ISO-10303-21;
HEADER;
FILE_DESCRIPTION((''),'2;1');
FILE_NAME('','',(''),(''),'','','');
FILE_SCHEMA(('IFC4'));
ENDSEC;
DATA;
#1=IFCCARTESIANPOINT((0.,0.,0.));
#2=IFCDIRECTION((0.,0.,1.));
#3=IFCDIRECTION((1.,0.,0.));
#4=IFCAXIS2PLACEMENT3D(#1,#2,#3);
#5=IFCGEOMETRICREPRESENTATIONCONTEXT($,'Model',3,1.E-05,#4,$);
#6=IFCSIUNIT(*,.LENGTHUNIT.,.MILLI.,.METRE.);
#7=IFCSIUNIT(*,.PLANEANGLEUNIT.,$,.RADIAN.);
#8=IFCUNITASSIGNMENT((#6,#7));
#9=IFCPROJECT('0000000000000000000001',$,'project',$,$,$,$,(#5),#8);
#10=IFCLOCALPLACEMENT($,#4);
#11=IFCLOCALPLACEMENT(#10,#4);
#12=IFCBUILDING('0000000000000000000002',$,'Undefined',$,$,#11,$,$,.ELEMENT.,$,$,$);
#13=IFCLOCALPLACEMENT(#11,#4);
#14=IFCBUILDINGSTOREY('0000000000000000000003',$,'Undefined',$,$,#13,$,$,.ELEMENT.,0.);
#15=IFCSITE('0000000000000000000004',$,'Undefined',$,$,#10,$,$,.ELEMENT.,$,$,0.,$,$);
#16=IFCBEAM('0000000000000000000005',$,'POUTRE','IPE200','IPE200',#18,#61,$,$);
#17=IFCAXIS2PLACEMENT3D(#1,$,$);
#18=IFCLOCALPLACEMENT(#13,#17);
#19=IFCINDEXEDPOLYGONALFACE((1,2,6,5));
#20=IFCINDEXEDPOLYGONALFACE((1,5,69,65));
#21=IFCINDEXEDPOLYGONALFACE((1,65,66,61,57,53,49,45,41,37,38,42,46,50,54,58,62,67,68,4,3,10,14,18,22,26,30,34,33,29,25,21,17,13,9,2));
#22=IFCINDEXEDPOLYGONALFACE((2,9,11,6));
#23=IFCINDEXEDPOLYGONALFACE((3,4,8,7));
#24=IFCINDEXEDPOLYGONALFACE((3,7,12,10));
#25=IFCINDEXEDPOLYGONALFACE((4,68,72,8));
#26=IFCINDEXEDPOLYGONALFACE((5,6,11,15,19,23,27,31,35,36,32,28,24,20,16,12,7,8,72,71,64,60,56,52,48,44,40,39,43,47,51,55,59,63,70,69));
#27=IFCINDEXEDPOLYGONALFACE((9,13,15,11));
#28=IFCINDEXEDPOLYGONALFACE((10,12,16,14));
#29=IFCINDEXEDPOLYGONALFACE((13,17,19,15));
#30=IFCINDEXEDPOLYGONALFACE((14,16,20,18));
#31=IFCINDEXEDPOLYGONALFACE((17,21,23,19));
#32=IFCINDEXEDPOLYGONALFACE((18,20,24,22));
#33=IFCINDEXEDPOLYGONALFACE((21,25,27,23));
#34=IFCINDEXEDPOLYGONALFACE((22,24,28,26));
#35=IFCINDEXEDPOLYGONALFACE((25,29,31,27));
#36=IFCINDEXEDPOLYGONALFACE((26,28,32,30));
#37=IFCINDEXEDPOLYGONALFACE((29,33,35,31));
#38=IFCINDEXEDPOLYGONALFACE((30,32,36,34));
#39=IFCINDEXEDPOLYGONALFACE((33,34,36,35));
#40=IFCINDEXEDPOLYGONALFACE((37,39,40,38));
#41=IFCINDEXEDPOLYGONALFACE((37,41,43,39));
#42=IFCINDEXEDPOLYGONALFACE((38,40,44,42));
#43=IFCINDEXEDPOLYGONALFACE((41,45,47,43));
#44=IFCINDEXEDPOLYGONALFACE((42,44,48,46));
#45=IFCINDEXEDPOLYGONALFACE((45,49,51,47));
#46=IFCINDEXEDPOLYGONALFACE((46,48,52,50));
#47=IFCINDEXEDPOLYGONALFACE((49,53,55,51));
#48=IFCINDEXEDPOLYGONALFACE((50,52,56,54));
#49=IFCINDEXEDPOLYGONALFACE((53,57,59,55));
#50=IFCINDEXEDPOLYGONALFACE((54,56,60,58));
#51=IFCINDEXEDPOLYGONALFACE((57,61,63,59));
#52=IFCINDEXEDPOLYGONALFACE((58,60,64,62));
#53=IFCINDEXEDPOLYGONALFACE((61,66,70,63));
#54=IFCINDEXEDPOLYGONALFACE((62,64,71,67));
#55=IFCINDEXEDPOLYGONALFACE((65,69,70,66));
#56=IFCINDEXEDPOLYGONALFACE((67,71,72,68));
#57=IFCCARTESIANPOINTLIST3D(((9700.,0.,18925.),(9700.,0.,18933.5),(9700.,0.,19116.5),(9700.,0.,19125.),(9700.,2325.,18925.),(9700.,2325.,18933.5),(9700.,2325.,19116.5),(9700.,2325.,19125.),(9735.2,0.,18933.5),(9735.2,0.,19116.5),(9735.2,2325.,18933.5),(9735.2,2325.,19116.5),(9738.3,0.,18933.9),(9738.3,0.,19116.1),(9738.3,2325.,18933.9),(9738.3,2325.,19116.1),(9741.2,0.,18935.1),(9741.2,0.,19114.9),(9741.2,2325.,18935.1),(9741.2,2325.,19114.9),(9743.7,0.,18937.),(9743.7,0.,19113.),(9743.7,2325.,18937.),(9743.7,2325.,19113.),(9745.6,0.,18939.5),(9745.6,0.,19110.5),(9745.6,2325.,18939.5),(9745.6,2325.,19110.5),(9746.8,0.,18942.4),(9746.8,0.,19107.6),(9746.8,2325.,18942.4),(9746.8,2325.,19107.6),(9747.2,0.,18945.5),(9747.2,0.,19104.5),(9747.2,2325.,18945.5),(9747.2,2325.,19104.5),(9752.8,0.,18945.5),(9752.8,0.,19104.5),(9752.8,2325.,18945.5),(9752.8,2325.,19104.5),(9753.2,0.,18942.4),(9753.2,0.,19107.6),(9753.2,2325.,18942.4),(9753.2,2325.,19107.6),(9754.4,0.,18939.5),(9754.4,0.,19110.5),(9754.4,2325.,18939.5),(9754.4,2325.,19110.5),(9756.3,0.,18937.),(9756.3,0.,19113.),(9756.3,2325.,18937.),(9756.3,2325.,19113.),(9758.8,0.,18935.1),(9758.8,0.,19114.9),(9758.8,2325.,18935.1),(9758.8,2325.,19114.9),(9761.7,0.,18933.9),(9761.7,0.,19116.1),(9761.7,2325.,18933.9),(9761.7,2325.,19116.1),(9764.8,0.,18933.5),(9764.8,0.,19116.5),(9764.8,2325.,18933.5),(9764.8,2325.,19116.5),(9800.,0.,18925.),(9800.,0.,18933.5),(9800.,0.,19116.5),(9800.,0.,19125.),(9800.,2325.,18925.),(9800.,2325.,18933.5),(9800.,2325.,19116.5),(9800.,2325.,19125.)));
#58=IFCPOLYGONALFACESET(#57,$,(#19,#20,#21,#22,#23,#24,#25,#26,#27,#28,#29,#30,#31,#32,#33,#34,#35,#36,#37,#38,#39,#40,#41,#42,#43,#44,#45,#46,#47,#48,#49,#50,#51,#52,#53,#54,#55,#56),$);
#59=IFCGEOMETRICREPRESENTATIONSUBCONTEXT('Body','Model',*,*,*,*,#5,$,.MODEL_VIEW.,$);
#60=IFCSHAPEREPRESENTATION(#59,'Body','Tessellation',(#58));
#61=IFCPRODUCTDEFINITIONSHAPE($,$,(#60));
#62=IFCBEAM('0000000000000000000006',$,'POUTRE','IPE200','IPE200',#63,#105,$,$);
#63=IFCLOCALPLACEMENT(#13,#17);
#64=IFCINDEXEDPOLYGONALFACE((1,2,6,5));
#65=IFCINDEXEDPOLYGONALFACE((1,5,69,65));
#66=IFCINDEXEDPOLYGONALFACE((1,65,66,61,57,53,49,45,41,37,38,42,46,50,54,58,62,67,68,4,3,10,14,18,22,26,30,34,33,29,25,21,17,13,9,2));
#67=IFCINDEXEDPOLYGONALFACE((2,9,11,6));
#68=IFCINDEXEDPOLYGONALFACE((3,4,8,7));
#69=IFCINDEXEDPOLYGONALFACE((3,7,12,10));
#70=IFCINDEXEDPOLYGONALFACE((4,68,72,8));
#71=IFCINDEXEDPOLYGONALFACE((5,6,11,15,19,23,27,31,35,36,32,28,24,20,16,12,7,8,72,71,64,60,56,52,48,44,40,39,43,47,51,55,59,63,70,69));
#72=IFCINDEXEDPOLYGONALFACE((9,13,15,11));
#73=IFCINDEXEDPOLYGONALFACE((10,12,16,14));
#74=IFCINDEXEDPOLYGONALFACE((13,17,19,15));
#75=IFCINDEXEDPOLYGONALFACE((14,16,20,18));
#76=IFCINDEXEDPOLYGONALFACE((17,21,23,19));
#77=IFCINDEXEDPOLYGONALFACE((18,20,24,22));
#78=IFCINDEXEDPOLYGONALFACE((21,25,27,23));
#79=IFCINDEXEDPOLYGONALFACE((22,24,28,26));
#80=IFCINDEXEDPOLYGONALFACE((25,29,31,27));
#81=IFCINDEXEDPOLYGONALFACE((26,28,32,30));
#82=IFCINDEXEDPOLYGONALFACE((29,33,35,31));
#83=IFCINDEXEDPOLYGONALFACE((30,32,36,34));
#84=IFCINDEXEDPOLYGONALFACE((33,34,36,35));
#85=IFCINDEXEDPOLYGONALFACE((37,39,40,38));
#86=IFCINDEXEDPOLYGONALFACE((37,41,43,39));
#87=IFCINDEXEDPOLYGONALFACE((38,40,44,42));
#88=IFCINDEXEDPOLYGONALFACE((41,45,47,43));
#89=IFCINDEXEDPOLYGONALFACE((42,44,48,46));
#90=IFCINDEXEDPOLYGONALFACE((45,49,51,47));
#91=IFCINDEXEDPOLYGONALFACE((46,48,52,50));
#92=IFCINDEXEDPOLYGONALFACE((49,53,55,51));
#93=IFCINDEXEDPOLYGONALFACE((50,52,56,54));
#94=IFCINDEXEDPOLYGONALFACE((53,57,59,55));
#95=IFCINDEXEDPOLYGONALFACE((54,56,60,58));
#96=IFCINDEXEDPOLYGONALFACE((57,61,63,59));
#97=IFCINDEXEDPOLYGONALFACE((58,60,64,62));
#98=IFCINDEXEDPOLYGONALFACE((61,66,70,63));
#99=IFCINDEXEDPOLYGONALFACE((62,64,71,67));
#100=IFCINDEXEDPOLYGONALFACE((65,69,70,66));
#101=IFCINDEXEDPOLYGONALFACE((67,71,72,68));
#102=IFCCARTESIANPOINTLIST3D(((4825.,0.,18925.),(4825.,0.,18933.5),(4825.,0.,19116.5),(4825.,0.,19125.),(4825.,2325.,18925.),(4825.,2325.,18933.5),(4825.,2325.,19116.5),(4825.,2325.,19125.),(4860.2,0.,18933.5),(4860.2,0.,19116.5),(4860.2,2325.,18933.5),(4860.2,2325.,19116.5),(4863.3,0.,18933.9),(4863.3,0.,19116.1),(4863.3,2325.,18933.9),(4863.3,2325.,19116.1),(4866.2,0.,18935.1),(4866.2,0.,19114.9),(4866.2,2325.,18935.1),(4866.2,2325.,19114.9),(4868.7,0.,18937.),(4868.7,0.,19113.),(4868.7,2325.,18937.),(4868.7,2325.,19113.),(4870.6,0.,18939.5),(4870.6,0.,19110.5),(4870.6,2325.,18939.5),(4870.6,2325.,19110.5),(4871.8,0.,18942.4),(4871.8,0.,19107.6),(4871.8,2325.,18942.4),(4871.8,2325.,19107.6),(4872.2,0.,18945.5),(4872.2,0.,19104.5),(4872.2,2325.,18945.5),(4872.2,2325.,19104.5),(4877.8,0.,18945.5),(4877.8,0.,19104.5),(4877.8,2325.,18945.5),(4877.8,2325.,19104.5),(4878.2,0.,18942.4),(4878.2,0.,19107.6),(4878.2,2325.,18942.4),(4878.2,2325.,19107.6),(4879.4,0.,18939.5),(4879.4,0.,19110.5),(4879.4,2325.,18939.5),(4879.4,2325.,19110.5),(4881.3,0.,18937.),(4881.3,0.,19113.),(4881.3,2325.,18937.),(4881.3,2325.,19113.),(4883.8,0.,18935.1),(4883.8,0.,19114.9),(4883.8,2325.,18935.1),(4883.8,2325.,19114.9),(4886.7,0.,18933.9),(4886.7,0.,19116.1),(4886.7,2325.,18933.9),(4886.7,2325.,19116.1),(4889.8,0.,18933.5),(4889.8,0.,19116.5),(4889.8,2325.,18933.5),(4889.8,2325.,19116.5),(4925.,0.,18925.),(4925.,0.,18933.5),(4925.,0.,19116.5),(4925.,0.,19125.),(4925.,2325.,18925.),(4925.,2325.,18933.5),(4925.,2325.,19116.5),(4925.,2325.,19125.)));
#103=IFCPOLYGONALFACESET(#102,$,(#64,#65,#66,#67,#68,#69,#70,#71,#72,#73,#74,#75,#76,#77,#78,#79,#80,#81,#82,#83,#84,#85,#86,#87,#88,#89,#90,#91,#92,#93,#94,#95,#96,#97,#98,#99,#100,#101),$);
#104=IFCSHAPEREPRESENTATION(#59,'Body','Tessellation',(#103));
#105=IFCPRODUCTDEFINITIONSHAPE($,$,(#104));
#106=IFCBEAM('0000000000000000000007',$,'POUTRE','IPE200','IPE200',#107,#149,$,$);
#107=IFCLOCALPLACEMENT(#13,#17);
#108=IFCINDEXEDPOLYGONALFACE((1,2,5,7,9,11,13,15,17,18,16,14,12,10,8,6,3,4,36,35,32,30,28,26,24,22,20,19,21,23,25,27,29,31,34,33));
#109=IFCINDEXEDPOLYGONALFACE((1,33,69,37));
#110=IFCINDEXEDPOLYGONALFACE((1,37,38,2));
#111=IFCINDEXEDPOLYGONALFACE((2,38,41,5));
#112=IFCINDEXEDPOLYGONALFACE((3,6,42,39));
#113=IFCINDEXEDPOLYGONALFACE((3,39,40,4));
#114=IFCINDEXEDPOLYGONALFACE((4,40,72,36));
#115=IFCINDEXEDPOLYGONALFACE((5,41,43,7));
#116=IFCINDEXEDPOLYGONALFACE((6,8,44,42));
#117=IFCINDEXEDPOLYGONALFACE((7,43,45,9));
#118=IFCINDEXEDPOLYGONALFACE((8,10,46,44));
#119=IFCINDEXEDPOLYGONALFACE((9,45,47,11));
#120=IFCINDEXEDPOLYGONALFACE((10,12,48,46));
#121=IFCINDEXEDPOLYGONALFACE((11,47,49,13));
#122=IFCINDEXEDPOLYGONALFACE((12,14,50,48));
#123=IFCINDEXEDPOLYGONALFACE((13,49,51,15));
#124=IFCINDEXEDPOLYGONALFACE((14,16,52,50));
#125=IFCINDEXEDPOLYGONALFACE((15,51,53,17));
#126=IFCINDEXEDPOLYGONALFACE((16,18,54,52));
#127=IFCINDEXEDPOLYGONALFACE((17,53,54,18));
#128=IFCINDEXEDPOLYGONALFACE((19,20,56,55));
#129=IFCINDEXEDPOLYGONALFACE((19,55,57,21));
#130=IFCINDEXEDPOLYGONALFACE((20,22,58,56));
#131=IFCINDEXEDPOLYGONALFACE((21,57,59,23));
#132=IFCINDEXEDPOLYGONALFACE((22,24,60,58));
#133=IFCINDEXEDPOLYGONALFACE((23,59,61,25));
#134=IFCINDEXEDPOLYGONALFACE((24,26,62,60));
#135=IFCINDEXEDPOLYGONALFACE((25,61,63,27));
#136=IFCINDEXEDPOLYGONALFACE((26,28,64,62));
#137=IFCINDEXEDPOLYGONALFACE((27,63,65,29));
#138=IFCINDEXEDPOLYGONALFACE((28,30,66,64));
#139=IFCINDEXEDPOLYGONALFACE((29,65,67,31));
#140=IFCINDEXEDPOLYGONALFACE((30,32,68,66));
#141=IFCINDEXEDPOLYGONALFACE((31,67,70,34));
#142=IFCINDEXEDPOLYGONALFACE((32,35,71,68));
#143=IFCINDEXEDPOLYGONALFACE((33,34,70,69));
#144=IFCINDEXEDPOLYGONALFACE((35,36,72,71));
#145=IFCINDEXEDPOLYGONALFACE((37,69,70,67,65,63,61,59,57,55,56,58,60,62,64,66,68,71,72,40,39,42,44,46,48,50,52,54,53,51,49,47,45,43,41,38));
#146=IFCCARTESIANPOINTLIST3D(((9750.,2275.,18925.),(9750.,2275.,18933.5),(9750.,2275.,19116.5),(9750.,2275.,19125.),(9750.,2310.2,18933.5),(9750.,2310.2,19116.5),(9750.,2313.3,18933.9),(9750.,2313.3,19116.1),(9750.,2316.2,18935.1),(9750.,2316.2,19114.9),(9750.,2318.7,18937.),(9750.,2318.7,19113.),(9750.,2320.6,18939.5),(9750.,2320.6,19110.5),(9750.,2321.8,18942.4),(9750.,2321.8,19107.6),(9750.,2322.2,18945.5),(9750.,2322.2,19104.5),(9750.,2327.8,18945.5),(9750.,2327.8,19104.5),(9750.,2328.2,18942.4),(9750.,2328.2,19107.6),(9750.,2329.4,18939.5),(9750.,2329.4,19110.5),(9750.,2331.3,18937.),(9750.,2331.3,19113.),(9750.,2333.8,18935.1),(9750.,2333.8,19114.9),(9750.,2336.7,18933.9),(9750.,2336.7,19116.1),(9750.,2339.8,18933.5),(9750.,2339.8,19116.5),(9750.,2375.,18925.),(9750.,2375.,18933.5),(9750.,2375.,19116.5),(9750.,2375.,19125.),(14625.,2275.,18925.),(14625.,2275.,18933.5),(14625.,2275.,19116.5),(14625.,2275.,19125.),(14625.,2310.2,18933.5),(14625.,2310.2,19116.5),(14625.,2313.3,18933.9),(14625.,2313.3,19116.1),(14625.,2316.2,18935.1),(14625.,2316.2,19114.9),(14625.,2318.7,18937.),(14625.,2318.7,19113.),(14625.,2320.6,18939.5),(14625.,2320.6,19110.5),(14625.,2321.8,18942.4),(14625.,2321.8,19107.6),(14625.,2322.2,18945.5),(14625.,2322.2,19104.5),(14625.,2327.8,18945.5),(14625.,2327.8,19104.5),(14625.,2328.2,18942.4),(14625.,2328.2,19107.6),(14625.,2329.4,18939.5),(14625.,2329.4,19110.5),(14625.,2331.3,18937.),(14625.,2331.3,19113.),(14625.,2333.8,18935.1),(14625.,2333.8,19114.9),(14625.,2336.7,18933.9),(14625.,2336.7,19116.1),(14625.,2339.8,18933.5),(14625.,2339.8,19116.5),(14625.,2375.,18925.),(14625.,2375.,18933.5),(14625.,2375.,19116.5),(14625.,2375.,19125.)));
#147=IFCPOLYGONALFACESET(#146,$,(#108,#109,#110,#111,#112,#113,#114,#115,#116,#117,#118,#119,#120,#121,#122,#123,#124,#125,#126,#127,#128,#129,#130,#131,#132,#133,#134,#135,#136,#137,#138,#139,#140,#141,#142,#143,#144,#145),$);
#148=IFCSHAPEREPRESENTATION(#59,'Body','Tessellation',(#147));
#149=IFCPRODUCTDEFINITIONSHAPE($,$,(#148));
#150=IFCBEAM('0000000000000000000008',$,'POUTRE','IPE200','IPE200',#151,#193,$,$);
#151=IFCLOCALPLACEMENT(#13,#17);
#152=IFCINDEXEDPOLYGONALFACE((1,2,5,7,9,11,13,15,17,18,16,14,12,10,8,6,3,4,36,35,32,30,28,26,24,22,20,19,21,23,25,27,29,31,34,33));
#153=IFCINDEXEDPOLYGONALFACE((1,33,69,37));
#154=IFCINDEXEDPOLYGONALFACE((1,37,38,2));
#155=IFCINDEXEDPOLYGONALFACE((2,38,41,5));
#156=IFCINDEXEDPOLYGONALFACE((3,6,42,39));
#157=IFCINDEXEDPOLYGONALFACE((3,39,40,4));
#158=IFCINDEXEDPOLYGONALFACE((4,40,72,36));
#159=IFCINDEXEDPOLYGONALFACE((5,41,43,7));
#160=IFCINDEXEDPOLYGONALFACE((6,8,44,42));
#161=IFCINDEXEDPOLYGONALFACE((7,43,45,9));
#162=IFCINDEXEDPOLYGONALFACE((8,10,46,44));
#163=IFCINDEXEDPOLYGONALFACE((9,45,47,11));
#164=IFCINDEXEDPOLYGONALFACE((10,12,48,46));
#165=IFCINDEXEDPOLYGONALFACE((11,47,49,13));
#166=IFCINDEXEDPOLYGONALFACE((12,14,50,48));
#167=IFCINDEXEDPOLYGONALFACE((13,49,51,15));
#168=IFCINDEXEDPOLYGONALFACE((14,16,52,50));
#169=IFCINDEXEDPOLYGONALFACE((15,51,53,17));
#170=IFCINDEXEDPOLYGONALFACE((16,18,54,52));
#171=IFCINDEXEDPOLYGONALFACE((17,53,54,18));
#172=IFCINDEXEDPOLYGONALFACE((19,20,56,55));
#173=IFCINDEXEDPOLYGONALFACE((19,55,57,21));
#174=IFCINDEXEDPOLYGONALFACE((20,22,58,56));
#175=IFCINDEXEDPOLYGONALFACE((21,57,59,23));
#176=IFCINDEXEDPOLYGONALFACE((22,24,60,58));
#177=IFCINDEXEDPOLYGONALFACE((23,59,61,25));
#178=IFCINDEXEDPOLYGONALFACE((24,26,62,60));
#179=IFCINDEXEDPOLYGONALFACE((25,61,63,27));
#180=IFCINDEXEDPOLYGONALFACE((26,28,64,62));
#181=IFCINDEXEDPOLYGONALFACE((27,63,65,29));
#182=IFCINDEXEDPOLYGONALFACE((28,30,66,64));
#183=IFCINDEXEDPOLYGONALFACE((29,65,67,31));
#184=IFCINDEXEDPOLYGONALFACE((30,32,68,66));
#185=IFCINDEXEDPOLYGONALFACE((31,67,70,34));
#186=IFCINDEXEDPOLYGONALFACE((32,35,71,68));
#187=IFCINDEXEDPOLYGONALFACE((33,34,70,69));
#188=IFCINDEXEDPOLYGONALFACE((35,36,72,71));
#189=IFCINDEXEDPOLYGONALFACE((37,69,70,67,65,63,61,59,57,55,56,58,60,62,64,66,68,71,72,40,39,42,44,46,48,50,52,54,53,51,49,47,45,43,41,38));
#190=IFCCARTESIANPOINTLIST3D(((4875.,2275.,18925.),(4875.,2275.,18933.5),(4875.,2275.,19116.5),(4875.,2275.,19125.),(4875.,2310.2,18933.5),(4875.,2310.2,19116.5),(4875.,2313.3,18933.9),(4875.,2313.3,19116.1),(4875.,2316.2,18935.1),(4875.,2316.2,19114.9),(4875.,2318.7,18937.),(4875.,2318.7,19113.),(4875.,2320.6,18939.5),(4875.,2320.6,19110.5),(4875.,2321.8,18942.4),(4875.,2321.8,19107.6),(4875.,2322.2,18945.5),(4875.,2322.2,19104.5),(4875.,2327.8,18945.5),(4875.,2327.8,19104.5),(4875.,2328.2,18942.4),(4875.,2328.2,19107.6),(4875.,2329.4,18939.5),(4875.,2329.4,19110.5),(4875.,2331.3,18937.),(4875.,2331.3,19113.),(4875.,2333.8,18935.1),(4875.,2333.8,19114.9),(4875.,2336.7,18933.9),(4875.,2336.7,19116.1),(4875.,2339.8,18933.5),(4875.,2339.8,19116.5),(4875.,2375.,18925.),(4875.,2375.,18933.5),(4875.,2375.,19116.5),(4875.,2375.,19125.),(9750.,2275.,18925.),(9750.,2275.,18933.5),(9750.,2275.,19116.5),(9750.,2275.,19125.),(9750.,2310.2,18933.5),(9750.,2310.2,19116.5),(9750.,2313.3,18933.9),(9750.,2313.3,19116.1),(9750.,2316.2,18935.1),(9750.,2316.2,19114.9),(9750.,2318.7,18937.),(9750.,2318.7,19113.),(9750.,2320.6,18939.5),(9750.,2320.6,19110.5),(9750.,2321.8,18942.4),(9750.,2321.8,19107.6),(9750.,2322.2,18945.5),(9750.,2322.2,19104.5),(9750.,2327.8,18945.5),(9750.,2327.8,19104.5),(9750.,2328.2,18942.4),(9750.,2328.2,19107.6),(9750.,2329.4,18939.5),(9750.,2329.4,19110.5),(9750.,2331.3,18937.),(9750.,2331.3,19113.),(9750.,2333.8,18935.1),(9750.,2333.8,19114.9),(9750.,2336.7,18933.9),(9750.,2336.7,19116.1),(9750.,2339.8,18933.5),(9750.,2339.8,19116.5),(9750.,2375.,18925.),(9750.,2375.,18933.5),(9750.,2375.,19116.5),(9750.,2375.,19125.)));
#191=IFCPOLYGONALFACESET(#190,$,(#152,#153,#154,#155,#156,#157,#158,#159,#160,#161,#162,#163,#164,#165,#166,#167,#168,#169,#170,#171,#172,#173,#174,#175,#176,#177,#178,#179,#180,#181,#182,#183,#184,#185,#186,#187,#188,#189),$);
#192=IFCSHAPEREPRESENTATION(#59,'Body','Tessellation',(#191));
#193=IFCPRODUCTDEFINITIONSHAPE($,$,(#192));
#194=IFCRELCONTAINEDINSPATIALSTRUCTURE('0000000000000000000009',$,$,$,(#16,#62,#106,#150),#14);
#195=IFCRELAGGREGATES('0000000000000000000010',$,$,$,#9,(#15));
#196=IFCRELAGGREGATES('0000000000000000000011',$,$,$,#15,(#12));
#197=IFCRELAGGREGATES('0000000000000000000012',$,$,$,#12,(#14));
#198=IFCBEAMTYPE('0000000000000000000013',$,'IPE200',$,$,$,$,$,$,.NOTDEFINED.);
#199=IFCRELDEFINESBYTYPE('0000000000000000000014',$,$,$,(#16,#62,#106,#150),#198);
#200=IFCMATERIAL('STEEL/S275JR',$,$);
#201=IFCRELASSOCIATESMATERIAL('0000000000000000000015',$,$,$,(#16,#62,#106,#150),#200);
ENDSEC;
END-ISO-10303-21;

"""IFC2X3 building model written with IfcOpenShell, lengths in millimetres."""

from ifc_helpers import new_model, si_unit, frame, origin_with_axes, origin_2d_with_axis, place, context, subcontext, project, spatial, i_section, extrude, material, type_object, element, save


model = new_model("IFC2X3")

# Units and contexts
model_context = context("Model", 3, precision=1e-05, world=origin_with_axes())
body_context = subcontext(model_context, "Body", "Model", "MODEL_VIEW")
ifc_project = project(units=[si_unit("LENGTHUNIT", "METRE", prefix="MILLI"), si_unit("PLANEANGLEUNIT", "RADIAN")], contexts=[model_context])

# Site, building, storey
site_placement = place(None, origin_with_axes())
site = spatial("IfcSite", under=ifc_project, at=site_placement, Name="Undefined", CompositionType="ELEMENT", RefElevation=0.0)
building_placement = place(site_placement, origin_with_axes())
building = spatial("IfcBuilding", under=site, at=building_placement, Name="Undefined", CompositionType="ELEMENT")
storey_placement = place(building_placement, origin_with_axes())
storey = spatial("IfcBuildingStorey", under=building, at=storey_placement, Name="Undefined", CompositionType="ELEMENT", Elevation=0.0)

# Shared definitions
ifc_material_1 = material(Name="STEEL/S275JR")

# Beams
beam_type_1 = type_object("IfcBeamType", Name="IPE200", PredefinedType="NOTDEFINED")
for number, where, z_axis, x_axis, name in (
    (1, (9750.0, 0.0, 19025.0), (0.0, 0.000013, 1.0), (0.0, 1.0, -0.000013), "POUTRE"),
    (2, (4875.0, 0.0, 19025.0), (0.0, 0.000013, 1.0), (0.0, 1.0, -0.000013), "POUTRE"),
):
    element("IfcBeam", number, at=place(storey_placement, frame(where, z_axis=z_axis, x_axis=x_axis)), inside=storey, type_object=beam_type_1, material=ifc_material_1, Name=name, Description="IPE200", ObjectType="IPE200", context=body_context, shape_type="SweptSolid", body=[
        extrude(i_section(OverallWidth=100.0, OverallDepth=200.0, WebThickness=5.6, FlangeThickness=8.5, FilletRadius=12.0, at=origin_2d_with_axis()), frame((2325.0, 0.0, 0.0), z_axis=(-1.0, 0.0, 0.0), x_axis=(0.0, -1.0, 0.0)), (0.0, 0.0, 1.0), 2325.0),
    ])
for number, where, z_axis, x_axis, name in (
    (3, (9750.0, 2325.0, 19025.0), (0.0, 0.0, 1.0), (1.0, 0.0, 0.0), "POUTRE"),
    (4, (4875.0, 2325.0, 19025.0), (0.0, 0.0, 1.0), (1.0, 0.0, 0.0), "POUTRE"),
):
    element("IfcBeam", number, at=place(storey_placement, frame(where, z_axis=z_axis, x_axis=x_axis)), inside=storey, type_object=beam_type_1, material=ifc_material_1, Name=name, Description="IPE200", ObjectType="IPE200", context=body_context, shape_type="SweptSolid", body=[
        extrude(i_section(OverallWidth=100.0, OverallDepth=200.0, WebThickness=5.6, FlangeThickness=8.5, FilletRadius=12.0, at=origin_2d_with_axis()), frame((4875.0, 0.0, 0.0), z_axis=(-1.0, 0.0, 0.0), x_axis=(0.0, -1.0, 0.0)), (0.0, 0.0, 1.0), 4875.0),
    ])

save(model, "model.ifc")
